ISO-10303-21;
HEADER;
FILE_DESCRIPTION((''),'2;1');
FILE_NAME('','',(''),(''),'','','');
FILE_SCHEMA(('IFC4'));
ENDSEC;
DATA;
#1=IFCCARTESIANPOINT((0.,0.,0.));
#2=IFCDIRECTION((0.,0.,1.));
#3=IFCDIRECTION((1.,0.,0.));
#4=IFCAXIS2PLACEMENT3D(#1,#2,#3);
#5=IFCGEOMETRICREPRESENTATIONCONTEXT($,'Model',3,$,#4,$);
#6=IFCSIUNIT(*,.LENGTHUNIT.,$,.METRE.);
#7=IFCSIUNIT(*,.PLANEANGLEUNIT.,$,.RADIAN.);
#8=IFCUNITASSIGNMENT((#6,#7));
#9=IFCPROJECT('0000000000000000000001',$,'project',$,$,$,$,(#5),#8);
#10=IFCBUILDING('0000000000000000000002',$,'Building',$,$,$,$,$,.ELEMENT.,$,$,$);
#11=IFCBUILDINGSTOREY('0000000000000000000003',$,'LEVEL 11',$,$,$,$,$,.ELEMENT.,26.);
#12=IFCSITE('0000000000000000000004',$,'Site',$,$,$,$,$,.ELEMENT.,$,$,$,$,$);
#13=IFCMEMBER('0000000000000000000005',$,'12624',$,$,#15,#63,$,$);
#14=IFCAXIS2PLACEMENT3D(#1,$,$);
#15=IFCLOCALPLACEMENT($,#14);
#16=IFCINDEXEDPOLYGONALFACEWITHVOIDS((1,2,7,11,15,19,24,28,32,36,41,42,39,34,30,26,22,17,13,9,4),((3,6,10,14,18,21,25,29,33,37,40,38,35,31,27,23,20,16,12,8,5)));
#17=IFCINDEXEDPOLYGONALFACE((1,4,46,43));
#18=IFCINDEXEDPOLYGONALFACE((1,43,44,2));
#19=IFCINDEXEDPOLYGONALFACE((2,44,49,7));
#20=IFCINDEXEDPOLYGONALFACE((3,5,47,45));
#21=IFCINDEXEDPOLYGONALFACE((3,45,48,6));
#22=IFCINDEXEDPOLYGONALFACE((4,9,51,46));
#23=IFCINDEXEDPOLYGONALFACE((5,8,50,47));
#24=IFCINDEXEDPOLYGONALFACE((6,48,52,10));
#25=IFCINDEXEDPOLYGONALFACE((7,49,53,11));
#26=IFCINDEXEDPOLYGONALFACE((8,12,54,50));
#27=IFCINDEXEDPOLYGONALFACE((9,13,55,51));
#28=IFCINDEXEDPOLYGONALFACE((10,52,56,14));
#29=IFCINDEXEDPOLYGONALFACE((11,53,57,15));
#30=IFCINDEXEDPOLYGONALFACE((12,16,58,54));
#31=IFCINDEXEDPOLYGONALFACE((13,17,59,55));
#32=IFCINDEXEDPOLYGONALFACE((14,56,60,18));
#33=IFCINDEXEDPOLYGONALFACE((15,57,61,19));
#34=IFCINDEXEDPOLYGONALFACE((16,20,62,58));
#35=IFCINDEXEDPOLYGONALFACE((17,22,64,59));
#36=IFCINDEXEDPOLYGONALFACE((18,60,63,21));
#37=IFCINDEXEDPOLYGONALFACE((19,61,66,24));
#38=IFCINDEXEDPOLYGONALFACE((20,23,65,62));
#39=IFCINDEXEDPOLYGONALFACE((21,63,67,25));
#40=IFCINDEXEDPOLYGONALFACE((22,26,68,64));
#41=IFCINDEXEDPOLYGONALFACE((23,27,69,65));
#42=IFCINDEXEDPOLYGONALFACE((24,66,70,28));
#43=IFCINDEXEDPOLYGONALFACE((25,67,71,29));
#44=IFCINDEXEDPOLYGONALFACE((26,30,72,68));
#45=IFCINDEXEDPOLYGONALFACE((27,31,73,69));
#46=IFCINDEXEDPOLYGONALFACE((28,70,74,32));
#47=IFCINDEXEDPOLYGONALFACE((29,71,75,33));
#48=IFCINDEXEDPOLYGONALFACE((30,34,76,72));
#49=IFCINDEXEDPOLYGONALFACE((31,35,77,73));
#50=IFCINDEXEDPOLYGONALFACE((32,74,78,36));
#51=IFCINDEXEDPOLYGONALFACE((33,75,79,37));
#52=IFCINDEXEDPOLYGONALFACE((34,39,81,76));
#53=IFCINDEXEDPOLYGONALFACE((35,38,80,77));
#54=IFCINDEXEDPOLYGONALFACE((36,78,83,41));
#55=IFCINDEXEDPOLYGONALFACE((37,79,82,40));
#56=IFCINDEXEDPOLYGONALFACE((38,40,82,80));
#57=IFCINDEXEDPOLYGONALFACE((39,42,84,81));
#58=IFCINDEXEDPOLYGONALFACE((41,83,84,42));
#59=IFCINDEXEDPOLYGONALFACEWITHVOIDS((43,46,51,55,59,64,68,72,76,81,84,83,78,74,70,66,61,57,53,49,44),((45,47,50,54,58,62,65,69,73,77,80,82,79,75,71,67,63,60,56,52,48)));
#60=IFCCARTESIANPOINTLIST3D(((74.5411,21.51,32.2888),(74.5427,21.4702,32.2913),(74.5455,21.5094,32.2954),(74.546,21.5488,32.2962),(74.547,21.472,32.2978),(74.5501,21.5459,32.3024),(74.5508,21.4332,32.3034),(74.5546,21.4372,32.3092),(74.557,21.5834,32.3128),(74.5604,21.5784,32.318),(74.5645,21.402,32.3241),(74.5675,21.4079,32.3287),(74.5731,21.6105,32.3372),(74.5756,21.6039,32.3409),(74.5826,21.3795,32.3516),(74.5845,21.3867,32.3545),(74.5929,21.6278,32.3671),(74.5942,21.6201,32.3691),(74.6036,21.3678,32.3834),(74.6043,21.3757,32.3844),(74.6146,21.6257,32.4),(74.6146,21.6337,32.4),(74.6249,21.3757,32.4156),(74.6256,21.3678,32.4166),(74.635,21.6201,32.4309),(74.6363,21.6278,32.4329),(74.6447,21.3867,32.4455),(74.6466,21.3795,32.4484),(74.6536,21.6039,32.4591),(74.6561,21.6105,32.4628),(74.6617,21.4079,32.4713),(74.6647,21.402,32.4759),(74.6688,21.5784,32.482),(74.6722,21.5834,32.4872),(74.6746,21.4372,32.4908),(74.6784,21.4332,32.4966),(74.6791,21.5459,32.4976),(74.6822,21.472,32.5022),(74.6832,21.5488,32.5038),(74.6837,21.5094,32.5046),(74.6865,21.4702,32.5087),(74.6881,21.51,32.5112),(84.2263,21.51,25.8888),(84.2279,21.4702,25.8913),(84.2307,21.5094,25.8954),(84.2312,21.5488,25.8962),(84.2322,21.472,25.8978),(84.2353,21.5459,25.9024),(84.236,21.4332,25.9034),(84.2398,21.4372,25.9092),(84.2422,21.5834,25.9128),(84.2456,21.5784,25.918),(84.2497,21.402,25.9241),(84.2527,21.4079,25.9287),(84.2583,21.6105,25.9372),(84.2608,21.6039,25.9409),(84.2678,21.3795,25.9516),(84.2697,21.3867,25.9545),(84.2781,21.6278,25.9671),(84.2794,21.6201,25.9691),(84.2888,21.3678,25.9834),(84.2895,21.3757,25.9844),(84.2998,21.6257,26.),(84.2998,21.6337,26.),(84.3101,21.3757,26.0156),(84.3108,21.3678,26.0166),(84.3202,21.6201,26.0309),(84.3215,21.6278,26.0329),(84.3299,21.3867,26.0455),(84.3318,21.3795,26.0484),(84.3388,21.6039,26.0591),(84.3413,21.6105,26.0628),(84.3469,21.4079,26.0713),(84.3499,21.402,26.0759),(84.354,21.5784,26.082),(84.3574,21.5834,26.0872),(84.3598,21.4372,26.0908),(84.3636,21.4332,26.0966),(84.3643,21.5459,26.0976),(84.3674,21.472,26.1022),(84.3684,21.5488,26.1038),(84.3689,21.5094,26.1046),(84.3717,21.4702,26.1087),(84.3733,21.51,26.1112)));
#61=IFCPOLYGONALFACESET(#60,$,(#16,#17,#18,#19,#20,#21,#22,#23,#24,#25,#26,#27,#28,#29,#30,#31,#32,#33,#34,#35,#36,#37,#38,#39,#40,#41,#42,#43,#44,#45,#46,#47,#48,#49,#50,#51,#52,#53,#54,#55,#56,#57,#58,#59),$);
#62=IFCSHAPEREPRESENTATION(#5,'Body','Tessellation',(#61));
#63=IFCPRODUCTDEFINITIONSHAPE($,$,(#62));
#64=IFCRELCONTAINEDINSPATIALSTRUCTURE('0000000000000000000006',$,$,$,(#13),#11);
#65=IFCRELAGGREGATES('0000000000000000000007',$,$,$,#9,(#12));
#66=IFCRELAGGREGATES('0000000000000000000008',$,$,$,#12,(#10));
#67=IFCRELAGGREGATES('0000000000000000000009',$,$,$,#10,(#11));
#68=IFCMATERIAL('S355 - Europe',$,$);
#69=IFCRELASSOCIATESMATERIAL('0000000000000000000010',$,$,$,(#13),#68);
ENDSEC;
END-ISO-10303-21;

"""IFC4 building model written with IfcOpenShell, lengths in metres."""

from ifc_helpers import new_model, si_unit, frame, origin_with_axes, origin_2d_with_axis, place, context, project, spatial, hollow_circle, extrude, material, material_profile, profile_set, profile_usage, element, save


model = new_model("IFC4")

# Units and contexts
model_context = context("Model", 3, world=origin_with_axes())
ifc_project = project(units=[si_unit("LENGTHUNIT", "METRE"), si_unit("PLANEANGLEUNIT", "RADIAN")], contexts=[model_context])

# Site, building, storey
site = spatial("IfcSite", under=ifc_project, Name="Site", CompositionType="ELEMENT")
building = spatial("IfcBuilding", under=site, Name="Building", CompositionType="ELEMENT")
storey = spatial("IfcBuildingStorey", under=building, Name="LEVEL 11", CompositionType="ELEMENT", Elevation=26.0)

# Shared definitions
ifc_material = material(Name="S355 - Europe")

# Member
ifc_material_profile_1 = material_profile(ifc_material, hollow_circle(Radius=0.1337, WallThickness=0.008, at=origin_2d_with_axis()))
ifc_profile_set_1 = profile_set([ifc_material_profile_1])
ifc_profile_usage_1 = profile_usage(ifc_profile_set_1, cardinal=10)
member_1_placement = place(None, frame((74.6146, 21.5, 32.4), z_axis=(0.834302, 0.0, -0.551308), x_axis=(0.0, 1.0, 0.0)))
element("IfcMember", 1, at=member_1_placement, inside=storey, material=ifc_profile_usage_1, Name="12624", context=model_context, shape_type="SweptSolid", body=[
    extrude(hollow_circle(Radius=0.1337, WallThickness=0.008, at=origin_2d_with_axis()), origin_with_axes(), (0.0, 0.0, 1.0), 11.6088),
])

save(model, "model.ifc")
